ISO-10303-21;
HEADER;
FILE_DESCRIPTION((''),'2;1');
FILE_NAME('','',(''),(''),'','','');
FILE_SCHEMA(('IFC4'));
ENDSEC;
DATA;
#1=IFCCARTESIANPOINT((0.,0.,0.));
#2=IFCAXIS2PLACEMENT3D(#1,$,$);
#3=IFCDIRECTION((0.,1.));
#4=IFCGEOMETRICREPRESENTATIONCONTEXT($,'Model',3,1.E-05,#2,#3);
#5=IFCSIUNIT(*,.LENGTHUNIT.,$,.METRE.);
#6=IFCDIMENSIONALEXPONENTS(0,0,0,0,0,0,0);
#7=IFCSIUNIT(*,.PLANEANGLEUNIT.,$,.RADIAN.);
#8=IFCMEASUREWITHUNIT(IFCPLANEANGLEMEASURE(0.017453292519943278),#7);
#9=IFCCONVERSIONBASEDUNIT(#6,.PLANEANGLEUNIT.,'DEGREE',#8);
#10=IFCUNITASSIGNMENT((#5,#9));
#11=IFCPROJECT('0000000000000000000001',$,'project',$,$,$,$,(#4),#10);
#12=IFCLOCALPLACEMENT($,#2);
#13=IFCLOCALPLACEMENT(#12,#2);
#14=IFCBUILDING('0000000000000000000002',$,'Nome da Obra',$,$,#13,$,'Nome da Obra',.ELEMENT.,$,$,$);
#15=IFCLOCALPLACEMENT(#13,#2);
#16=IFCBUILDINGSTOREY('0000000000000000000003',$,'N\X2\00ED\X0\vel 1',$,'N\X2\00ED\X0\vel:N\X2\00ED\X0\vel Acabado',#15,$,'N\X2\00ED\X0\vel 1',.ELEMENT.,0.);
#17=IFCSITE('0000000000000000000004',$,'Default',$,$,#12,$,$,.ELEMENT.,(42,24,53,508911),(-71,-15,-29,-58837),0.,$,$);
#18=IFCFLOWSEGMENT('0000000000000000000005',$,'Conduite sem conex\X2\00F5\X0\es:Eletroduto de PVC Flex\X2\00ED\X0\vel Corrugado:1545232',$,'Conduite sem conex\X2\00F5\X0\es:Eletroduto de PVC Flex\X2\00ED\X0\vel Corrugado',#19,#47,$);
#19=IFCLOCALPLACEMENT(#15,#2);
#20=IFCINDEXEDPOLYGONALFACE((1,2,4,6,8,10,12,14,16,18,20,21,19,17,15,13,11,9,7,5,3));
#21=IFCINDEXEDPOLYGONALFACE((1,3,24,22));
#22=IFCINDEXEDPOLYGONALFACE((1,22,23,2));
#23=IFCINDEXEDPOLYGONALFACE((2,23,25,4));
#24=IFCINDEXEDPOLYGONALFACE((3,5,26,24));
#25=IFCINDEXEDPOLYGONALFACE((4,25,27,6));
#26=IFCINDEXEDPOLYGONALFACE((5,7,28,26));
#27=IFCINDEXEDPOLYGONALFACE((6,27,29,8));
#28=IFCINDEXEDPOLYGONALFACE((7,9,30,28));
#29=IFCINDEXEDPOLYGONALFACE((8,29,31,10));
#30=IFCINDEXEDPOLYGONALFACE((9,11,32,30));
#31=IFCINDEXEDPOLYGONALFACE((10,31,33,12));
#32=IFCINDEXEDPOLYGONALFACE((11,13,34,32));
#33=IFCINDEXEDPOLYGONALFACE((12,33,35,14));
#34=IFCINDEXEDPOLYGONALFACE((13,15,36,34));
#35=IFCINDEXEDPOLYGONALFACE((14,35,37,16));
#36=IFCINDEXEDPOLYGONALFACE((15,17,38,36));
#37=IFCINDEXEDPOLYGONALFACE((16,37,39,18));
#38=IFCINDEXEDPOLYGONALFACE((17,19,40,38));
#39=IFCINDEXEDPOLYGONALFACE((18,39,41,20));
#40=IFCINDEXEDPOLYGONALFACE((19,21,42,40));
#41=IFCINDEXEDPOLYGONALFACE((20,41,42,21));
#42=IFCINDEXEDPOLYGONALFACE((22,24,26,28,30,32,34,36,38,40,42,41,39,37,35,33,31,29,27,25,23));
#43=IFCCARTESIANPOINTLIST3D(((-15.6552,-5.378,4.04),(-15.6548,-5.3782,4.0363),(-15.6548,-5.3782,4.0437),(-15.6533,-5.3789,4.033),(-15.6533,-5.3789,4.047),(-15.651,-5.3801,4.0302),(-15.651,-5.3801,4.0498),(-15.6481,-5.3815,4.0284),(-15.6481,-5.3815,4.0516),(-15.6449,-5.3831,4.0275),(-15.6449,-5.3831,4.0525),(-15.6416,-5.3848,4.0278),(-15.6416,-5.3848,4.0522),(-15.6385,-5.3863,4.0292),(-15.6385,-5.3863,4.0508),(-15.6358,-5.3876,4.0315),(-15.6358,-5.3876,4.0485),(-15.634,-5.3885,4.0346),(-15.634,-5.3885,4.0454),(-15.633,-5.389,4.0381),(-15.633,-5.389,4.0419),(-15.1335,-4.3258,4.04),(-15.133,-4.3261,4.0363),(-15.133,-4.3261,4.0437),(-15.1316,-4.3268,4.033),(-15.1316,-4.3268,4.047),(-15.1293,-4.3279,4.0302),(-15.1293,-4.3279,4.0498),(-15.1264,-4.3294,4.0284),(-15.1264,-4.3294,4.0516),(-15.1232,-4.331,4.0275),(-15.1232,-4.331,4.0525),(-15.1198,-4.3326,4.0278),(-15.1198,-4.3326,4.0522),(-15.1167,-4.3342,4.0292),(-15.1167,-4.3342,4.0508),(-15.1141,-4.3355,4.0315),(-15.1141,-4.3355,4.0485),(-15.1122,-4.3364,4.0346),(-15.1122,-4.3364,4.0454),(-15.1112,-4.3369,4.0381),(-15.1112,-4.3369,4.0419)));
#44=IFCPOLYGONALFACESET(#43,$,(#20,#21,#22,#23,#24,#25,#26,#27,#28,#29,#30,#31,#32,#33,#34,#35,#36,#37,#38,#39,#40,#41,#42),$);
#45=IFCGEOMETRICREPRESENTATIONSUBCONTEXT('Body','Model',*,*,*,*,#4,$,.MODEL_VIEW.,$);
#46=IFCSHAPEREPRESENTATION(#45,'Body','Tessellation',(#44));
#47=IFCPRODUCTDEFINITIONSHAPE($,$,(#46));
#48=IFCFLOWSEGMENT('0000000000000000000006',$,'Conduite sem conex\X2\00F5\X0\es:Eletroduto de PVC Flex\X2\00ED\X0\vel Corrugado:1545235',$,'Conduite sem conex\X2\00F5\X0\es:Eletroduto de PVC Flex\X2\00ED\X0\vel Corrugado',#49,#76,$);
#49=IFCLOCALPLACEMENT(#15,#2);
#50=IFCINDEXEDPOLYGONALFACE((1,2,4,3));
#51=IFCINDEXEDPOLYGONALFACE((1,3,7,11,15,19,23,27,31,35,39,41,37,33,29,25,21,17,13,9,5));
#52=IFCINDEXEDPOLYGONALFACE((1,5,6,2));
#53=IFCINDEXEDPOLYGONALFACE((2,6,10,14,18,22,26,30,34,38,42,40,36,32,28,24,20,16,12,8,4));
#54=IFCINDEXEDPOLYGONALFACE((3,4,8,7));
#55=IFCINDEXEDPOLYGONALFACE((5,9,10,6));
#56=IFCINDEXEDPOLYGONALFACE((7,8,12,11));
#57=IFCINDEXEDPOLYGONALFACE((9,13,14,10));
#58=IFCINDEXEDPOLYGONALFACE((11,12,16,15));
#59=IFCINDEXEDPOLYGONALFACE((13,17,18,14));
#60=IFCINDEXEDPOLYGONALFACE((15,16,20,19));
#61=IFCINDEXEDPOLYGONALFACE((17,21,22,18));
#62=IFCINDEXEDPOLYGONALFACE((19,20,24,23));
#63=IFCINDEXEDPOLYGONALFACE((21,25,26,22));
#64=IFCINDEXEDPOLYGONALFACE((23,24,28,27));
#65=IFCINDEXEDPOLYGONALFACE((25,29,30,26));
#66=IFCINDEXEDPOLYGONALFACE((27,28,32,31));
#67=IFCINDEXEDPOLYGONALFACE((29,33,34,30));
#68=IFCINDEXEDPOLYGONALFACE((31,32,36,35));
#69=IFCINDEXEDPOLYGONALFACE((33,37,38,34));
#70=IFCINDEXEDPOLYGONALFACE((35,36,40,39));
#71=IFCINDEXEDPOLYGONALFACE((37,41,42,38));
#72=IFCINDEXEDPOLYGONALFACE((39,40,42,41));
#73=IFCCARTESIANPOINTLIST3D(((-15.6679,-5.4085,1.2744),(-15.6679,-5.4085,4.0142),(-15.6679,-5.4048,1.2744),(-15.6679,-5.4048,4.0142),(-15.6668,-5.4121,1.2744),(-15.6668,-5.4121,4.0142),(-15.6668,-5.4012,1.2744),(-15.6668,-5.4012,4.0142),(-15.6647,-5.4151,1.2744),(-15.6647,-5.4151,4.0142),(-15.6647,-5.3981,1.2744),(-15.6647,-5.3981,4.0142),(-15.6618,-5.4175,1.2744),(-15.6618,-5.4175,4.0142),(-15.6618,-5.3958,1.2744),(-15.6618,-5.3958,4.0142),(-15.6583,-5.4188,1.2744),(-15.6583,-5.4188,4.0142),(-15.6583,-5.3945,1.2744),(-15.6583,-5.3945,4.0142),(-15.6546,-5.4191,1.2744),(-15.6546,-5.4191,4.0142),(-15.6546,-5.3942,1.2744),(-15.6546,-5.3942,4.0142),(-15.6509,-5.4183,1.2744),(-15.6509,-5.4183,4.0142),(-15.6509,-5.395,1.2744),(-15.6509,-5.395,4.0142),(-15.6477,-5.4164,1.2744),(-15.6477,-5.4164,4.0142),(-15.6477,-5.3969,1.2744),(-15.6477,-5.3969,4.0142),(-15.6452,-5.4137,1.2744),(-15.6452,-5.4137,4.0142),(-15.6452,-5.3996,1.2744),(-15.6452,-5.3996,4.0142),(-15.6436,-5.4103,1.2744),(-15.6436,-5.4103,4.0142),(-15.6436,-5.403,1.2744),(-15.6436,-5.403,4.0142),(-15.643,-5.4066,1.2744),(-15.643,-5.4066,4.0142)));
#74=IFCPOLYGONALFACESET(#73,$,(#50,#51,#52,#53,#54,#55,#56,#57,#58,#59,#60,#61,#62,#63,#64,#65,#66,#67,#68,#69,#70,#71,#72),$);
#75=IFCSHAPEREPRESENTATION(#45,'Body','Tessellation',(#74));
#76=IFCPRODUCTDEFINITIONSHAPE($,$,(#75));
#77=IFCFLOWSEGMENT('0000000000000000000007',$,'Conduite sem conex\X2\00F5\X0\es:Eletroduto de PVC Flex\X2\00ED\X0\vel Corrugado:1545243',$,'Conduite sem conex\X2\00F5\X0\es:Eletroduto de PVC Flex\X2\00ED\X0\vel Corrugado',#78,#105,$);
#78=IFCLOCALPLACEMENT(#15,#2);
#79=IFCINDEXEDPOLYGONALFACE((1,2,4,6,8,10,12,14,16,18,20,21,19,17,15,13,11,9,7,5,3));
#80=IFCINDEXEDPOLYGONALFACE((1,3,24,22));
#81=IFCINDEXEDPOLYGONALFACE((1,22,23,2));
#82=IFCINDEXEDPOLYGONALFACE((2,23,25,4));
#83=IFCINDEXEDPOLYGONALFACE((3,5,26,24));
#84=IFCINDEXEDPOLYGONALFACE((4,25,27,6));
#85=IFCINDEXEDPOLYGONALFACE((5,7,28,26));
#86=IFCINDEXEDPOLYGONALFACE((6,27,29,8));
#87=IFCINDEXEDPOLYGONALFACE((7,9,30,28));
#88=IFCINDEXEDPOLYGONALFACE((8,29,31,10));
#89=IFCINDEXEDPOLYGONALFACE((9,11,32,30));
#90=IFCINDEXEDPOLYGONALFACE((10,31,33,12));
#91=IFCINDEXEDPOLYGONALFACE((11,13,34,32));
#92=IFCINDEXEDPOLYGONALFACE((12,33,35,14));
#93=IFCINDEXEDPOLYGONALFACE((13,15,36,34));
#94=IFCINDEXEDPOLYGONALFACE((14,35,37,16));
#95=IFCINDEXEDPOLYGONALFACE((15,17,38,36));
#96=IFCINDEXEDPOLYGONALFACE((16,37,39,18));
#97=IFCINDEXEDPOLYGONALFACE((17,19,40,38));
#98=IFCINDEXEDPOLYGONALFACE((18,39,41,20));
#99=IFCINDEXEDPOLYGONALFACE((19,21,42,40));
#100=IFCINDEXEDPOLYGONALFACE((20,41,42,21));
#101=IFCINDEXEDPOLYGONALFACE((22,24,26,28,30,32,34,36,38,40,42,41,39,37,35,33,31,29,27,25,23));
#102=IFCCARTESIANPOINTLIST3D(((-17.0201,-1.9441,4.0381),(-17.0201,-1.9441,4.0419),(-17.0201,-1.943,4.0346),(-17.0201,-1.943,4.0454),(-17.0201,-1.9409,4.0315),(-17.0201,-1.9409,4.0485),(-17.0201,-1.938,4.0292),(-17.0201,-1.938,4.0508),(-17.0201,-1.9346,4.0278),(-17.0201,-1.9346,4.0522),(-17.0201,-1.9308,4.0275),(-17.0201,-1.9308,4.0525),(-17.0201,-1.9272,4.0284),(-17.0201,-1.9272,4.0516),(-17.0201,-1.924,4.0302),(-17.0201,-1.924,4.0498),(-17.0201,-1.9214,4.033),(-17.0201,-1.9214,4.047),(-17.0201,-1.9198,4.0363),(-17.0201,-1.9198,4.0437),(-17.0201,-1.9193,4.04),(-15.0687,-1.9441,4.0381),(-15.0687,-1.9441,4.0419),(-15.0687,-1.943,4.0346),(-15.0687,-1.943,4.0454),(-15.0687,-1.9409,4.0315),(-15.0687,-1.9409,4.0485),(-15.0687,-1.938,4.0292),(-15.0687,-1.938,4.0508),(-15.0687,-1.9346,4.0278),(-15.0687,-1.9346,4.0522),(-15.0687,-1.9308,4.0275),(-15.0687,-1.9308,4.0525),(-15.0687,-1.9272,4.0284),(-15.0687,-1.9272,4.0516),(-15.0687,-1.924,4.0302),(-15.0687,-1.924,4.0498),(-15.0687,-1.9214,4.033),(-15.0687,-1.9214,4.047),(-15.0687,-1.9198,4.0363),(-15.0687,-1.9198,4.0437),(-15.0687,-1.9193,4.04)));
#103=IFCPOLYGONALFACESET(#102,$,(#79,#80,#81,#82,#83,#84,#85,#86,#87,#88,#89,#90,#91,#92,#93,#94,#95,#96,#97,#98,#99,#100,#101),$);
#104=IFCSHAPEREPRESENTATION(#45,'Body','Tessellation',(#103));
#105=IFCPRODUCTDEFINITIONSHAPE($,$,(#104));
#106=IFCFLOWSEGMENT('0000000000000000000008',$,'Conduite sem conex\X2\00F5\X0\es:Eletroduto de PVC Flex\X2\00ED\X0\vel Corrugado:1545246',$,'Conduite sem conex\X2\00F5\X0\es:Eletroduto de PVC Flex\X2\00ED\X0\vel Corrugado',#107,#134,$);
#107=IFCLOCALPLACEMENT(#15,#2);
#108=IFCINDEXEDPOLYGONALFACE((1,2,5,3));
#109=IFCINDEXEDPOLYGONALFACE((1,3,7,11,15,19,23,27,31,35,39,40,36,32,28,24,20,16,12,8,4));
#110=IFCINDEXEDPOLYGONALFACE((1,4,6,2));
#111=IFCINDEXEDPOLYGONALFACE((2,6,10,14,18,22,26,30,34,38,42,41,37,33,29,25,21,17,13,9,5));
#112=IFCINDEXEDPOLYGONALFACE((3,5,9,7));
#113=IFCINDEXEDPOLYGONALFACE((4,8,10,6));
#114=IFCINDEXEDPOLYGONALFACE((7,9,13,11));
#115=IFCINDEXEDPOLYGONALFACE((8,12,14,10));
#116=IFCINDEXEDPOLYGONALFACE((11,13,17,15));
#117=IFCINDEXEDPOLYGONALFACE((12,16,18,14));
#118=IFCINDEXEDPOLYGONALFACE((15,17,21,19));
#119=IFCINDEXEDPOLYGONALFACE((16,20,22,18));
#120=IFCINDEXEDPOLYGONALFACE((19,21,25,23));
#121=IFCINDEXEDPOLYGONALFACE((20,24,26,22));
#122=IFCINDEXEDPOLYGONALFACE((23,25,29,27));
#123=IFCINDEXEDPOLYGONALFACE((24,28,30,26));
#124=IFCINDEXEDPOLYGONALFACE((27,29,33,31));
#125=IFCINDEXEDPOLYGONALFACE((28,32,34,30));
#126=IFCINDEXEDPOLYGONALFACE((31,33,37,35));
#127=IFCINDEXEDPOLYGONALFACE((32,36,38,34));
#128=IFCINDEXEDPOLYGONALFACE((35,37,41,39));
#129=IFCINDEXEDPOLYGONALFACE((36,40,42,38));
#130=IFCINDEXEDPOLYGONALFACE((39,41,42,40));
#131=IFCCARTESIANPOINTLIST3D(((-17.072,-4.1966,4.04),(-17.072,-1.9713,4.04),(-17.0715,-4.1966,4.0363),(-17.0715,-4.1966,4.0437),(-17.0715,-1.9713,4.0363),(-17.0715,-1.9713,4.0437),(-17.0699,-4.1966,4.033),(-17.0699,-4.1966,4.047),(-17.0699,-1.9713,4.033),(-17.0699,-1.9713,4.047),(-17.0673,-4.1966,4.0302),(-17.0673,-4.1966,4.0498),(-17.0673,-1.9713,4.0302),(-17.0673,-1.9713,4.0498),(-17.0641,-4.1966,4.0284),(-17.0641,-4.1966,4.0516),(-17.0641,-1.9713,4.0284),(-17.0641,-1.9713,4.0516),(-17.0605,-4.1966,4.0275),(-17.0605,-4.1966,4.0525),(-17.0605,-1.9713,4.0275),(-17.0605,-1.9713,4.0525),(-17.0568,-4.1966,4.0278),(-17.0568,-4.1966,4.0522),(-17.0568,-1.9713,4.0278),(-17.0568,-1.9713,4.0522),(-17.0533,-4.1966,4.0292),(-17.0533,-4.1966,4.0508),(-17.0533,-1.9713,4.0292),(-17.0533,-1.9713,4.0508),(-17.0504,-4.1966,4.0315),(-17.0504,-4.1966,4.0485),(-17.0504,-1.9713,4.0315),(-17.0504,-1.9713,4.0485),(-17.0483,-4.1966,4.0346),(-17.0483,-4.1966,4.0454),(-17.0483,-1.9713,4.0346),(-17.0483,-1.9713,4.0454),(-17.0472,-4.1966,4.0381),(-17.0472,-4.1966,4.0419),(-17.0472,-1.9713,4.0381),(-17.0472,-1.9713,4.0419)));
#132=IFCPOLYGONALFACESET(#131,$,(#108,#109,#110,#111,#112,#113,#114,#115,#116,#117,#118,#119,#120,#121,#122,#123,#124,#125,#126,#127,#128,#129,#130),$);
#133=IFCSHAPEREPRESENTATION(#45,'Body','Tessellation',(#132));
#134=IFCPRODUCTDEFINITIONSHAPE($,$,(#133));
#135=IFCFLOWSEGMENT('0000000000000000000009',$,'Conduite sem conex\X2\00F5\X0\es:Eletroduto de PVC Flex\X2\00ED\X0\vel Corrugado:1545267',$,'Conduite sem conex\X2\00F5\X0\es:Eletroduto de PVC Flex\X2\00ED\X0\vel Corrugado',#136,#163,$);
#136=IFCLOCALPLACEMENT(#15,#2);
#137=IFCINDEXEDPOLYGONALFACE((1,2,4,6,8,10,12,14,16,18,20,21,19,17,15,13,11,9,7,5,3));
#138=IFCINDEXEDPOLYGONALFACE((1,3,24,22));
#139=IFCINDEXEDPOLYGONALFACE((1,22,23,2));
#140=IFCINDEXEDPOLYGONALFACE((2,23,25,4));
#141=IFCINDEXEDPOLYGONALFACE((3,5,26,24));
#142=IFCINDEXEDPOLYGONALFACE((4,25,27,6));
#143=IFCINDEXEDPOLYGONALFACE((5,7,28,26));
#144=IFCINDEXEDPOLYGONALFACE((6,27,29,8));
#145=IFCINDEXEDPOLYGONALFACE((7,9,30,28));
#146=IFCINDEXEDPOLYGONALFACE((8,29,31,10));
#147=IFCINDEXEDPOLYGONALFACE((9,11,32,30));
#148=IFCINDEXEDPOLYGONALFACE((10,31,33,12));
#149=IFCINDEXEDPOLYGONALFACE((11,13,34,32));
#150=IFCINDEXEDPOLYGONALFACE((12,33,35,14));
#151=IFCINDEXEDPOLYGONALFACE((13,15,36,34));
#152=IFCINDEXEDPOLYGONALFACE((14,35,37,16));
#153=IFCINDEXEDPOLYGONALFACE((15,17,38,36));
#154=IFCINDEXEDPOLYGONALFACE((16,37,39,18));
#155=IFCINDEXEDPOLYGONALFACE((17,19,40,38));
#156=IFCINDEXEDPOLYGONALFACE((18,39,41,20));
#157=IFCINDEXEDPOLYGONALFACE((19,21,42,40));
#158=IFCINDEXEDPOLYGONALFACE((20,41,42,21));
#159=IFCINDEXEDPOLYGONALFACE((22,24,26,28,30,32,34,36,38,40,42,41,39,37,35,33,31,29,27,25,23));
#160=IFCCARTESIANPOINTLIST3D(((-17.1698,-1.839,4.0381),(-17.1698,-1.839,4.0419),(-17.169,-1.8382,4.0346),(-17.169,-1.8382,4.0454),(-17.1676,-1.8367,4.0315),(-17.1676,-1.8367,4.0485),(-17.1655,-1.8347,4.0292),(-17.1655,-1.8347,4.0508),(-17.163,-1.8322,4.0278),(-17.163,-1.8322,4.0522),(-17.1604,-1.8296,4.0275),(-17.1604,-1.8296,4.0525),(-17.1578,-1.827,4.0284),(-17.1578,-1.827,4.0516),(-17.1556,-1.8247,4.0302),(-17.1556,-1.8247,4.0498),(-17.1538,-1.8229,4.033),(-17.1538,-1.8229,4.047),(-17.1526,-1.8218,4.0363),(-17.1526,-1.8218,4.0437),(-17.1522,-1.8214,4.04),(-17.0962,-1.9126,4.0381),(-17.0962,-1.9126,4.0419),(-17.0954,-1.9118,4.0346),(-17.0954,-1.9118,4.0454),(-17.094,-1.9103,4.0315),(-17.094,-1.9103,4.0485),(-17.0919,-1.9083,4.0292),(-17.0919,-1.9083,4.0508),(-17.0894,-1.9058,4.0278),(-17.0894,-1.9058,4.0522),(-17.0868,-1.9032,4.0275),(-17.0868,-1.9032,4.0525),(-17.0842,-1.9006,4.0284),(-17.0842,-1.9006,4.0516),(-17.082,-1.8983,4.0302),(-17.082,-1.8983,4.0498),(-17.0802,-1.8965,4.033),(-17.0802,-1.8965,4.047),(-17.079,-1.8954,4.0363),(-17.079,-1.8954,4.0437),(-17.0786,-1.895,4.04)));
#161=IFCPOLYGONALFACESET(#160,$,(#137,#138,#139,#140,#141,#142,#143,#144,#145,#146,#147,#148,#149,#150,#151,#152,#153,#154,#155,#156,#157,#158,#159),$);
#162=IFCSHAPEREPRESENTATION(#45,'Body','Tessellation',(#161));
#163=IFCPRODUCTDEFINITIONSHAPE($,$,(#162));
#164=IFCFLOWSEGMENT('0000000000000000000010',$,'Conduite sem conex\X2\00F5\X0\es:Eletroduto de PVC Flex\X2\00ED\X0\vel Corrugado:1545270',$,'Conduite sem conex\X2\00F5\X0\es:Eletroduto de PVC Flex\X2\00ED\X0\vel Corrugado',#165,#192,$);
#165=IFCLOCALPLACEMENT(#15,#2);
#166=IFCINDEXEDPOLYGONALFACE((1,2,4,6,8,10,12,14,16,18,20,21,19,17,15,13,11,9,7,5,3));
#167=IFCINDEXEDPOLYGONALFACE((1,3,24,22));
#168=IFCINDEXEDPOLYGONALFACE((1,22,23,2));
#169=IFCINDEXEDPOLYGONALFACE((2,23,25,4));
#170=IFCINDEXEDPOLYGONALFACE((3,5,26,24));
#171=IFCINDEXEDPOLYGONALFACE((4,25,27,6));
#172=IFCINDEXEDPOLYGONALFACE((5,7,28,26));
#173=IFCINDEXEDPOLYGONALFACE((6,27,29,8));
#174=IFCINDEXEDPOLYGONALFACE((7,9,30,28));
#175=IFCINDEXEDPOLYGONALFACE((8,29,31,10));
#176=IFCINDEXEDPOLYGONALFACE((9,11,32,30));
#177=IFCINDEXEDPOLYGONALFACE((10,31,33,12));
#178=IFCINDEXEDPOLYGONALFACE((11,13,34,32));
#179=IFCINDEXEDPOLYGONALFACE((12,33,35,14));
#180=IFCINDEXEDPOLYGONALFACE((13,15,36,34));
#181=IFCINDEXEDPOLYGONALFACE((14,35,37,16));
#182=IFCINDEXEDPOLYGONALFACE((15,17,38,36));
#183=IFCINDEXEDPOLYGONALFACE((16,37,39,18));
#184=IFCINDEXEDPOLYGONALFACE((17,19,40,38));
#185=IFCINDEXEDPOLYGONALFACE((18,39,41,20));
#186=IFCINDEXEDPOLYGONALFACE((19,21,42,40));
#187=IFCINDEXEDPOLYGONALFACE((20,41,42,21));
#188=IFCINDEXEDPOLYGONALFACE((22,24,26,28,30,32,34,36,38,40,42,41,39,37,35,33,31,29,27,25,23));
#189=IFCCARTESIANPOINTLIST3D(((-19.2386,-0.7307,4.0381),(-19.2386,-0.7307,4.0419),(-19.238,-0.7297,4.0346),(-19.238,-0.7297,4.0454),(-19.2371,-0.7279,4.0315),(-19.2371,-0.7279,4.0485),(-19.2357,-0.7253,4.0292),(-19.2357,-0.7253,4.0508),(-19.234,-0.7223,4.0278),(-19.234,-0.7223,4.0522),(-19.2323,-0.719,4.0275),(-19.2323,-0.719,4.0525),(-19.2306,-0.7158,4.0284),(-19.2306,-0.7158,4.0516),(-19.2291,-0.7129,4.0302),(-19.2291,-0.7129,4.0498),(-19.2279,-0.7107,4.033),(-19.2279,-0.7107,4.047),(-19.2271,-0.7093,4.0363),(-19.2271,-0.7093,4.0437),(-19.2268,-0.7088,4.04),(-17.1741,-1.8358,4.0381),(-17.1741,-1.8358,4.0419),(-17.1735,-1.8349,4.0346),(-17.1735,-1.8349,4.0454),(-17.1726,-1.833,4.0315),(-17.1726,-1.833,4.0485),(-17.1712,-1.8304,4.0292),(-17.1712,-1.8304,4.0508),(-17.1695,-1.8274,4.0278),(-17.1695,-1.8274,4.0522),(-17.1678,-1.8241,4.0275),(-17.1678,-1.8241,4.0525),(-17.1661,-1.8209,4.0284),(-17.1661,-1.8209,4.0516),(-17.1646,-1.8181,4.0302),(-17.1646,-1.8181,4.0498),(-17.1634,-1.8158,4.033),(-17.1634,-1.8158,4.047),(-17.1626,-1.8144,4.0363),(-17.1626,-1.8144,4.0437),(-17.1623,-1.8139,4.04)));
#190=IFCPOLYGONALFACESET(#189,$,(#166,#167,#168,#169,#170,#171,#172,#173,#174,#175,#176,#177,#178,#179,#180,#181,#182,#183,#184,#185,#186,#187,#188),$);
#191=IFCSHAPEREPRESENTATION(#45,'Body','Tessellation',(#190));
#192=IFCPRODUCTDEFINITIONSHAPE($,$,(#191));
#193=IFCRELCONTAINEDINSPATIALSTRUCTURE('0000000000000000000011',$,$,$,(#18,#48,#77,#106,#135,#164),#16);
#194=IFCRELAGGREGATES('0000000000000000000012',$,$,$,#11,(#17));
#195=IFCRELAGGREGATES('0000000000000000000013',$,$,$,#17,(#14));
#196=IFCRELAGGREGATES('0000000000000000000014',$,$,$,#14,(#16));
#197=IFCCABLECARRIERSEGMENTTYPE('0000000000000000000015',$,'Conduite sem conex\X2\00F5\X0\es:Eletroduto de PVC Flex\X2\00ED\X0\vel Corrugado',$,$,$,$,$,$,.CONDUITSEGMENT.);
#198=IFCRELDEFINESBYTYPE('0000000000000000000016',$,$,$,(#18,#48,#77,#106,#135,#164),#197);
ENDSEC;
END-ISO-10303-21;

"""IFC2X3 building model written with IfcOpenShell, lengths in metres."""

from ifc_helpers import new_model, entity, si_unit, converted_unit, direction, frame, frame_2d, origin, origin_2d_with_axis, place, context, subcontext, project, spatial, circle, extrude, type_object, element, save


model = new_model("IFC2X3")

# Units and contexts
model_context = context("Model", 3, precision=1e-05, world=origin(), true_north=direction((0.0, 1.0)))
body_context = subcontext(model_context, "Body", "Model", "MODEL_VIEW")
ifc_project = project(units=[si_unit("LENGTHUNIT", "METRE"), converted_unit("PLANEANGLEUNIT", "DEGREE", entity("IfcPlaneAngleMeasure", 0.017453292519943278), si_unit("PLANEANGLEUNIT", "RADIAN"), dimensions=[0, 0, 0, 0, 0, 0, 0])], contexts=[model_context])

# Site, building, storey
site_placement = place(None, origin())
site = spatial("IfcSite", under=ifc_project, at=site_placement, Name="Default", CompositionType="ELEMENT", RefLatitude=(42, 24, 53, 508911), RefLongitude=(-71, -15, -29, -58837), RefElevation=0.0)
building_placement = place(site_placement, origin())
building = spatial("IfcBuilding", under=site, at=building_placement, Name="Nome da Obra", LongName="Nome da Obra", CompositionType="ELEMENT")
storey_placement = place(building_placement, origin())
storey = spatial("IfcBuildingStorey", under=building, at=storey_placement, Name="Nível 1", ObjectType="Nível:Nível Acabado", LongName="Nível 1", CompositionType="ELEMENT", Elevation=0.0)

# Flow segments
cable_carrier_segment_type = type_object("IfcCableCarrierSegmentType", Name="Conduite sem conexões:Eletroduto de PVC Flexível Corrugado", PredefinedType="CONDUITSEGMENT")
flow_segment_1_placement = place(storey_placement, origin())
element("IfcFlowSegment", 1, at=flow_segment_1_placement, inside=storey, type_object=cable_carrier_segment_type, Name="Conduite sem conexões:Eletroduto de PVC Flexível Corrugado:1545232", ObjectType="Conduite sem conexões:Eletroduto de PVC Flexível Corrugado", context=body_context, shape_type="SweptSolid", body=[
    extrude(circle(Radius=0.0125, at=frame_2d((0.0, 0.0), x_axis=(1.0, 0.0))), frame((-15.644, -5.3835, 4.04), z_axis=(0.444255, 0.8959, 0.0), x_axis=(-0.8959, 0.444255, 0.0)), (0.0, 0.0, 1.0), 1.1744),
])
flow_segment_2_placement = place(storey_placement, origin())
element("IfcFlowSegment", 2, at=flow_segment_2_placement, inside=storey, type_object=cable_carrier_segment_type, Name="Conduite sem conexões:Eletroduto de PVC Flexível Corrugado:1545235", ObjectType="Conduite sem conexões:Eletroduto de PVC Flexível Corrugado", context=body_context, shape_type="SweptSolid", body=[
    extrude(circle(Radius=0.0125, at=frame_2d((0.0, 0.0), x_axis=(1.0, 0.0))), frame((-15.6555, -5.4066, 1.2744)), (0.0, 0.0, 1.0), 2.7398),
])
flow_segment_3_placement = place(storey_placement, origin())
element("IfcFlowSegment", 3, at=flow_segment_3_placement, inside=storey, type_object=cable_carrier_segment_type, Name="Conduite sem conexões:Eletroduto de PVC Flexível Corrugado:1545243", ObjectType="Conduite sem conexões:Eletroduto de PVC Flexível Corrugado", context=body_context, shape_type="SweptSolid", body=[
    extrude(circle(Radius=0.0125, at=frame_2d((0.0, 0.0), x_axis=(1.0, 0.0))), frame((-17.0201, -1.9318, 4.04), z_axis=(1.0, 0.0, 0.0), x_axis=(0.0, 1.0, 0.0)), (0.0, 0.0, 1.0), 1.9514),
])
flow_segment_4_placement = place(storey_placement, origin())
element("IfcFlowSegment", 4, at=flow_segment_4_placement, inside=storey, type_object=cable_carrier_segment_type, Name="Conduite sem conexões:Eletroduto de PVC Flexível Corrugado:1545246", ObjectType="Conduite sem conexões:Eletroduto de PVC Flexível Corrugado", context=body_context, shape_type="SweptSolid", body=[
    extrude(circle(Radius=0.0125, at=frame_2d((0.0, 0.0), x_axis=(1.0, 0.0))), frame((-17.0595, -4.1966, 4.04), z_axis=(0.0, 1.0, 0.0), x_axis=(-1.0, 0.0, 0.0)), (0.0, 0.0, 1.0), 2.2253),
])
flow_segment_5_placement = place(storey_placement, origin())
element("IfcFlowSegment", 5, at=flow_segment_5_placement, inside=storey, type_object=cable_carrier_segment_type, Name="Conduite sem conexões:Eletroduto de PVC Flexível Corrugado:1545267", ObjectType="Conduite sem conexões:Eletroduto de PVC Flexível Corrugado", context=body_context, shape_type="SweptSolid", body=[
    extrude(circle(Radius=0.0125, at=frame_2d((0.0, 0.0), x_axis=(1.0, 0.0))), frame((-17.1611, -1.8302, 4.04), z_axis=(0.707107, -0.707107, 0.0), x_axis=(0.707107, 0.707107, 0.0)), (0.0, 0.0, 1.0), 0.1041),
])
flow_segment_6_placement = place(storey_placement, origin())
element("IfcFlowSegment", 6, at=flow_segment_6_placement, inside=storey, type_object=cable_carrier_segment_type, Name="Conduite sem conexões:Eletroduto de PVC Flexível Corrugado:1545270", ObjectType="Conduite sem conexões:Eletroduto de PVC Flexível Corrugado", context=body_context, shape_type="SweptSolid", body=[
    extrude(circle(Radius=0.0125, at=origin_2d_with_axis()), frame((-17.1682, -1.8249, 4.04), z_axis=(-0.88163, 0.471941, 0.0), x_axis=(0.471941, 0.88163, 0.0)), (0.0, 0.0, 1.0), 2.3417),
])

save(model, "model.ifc")
